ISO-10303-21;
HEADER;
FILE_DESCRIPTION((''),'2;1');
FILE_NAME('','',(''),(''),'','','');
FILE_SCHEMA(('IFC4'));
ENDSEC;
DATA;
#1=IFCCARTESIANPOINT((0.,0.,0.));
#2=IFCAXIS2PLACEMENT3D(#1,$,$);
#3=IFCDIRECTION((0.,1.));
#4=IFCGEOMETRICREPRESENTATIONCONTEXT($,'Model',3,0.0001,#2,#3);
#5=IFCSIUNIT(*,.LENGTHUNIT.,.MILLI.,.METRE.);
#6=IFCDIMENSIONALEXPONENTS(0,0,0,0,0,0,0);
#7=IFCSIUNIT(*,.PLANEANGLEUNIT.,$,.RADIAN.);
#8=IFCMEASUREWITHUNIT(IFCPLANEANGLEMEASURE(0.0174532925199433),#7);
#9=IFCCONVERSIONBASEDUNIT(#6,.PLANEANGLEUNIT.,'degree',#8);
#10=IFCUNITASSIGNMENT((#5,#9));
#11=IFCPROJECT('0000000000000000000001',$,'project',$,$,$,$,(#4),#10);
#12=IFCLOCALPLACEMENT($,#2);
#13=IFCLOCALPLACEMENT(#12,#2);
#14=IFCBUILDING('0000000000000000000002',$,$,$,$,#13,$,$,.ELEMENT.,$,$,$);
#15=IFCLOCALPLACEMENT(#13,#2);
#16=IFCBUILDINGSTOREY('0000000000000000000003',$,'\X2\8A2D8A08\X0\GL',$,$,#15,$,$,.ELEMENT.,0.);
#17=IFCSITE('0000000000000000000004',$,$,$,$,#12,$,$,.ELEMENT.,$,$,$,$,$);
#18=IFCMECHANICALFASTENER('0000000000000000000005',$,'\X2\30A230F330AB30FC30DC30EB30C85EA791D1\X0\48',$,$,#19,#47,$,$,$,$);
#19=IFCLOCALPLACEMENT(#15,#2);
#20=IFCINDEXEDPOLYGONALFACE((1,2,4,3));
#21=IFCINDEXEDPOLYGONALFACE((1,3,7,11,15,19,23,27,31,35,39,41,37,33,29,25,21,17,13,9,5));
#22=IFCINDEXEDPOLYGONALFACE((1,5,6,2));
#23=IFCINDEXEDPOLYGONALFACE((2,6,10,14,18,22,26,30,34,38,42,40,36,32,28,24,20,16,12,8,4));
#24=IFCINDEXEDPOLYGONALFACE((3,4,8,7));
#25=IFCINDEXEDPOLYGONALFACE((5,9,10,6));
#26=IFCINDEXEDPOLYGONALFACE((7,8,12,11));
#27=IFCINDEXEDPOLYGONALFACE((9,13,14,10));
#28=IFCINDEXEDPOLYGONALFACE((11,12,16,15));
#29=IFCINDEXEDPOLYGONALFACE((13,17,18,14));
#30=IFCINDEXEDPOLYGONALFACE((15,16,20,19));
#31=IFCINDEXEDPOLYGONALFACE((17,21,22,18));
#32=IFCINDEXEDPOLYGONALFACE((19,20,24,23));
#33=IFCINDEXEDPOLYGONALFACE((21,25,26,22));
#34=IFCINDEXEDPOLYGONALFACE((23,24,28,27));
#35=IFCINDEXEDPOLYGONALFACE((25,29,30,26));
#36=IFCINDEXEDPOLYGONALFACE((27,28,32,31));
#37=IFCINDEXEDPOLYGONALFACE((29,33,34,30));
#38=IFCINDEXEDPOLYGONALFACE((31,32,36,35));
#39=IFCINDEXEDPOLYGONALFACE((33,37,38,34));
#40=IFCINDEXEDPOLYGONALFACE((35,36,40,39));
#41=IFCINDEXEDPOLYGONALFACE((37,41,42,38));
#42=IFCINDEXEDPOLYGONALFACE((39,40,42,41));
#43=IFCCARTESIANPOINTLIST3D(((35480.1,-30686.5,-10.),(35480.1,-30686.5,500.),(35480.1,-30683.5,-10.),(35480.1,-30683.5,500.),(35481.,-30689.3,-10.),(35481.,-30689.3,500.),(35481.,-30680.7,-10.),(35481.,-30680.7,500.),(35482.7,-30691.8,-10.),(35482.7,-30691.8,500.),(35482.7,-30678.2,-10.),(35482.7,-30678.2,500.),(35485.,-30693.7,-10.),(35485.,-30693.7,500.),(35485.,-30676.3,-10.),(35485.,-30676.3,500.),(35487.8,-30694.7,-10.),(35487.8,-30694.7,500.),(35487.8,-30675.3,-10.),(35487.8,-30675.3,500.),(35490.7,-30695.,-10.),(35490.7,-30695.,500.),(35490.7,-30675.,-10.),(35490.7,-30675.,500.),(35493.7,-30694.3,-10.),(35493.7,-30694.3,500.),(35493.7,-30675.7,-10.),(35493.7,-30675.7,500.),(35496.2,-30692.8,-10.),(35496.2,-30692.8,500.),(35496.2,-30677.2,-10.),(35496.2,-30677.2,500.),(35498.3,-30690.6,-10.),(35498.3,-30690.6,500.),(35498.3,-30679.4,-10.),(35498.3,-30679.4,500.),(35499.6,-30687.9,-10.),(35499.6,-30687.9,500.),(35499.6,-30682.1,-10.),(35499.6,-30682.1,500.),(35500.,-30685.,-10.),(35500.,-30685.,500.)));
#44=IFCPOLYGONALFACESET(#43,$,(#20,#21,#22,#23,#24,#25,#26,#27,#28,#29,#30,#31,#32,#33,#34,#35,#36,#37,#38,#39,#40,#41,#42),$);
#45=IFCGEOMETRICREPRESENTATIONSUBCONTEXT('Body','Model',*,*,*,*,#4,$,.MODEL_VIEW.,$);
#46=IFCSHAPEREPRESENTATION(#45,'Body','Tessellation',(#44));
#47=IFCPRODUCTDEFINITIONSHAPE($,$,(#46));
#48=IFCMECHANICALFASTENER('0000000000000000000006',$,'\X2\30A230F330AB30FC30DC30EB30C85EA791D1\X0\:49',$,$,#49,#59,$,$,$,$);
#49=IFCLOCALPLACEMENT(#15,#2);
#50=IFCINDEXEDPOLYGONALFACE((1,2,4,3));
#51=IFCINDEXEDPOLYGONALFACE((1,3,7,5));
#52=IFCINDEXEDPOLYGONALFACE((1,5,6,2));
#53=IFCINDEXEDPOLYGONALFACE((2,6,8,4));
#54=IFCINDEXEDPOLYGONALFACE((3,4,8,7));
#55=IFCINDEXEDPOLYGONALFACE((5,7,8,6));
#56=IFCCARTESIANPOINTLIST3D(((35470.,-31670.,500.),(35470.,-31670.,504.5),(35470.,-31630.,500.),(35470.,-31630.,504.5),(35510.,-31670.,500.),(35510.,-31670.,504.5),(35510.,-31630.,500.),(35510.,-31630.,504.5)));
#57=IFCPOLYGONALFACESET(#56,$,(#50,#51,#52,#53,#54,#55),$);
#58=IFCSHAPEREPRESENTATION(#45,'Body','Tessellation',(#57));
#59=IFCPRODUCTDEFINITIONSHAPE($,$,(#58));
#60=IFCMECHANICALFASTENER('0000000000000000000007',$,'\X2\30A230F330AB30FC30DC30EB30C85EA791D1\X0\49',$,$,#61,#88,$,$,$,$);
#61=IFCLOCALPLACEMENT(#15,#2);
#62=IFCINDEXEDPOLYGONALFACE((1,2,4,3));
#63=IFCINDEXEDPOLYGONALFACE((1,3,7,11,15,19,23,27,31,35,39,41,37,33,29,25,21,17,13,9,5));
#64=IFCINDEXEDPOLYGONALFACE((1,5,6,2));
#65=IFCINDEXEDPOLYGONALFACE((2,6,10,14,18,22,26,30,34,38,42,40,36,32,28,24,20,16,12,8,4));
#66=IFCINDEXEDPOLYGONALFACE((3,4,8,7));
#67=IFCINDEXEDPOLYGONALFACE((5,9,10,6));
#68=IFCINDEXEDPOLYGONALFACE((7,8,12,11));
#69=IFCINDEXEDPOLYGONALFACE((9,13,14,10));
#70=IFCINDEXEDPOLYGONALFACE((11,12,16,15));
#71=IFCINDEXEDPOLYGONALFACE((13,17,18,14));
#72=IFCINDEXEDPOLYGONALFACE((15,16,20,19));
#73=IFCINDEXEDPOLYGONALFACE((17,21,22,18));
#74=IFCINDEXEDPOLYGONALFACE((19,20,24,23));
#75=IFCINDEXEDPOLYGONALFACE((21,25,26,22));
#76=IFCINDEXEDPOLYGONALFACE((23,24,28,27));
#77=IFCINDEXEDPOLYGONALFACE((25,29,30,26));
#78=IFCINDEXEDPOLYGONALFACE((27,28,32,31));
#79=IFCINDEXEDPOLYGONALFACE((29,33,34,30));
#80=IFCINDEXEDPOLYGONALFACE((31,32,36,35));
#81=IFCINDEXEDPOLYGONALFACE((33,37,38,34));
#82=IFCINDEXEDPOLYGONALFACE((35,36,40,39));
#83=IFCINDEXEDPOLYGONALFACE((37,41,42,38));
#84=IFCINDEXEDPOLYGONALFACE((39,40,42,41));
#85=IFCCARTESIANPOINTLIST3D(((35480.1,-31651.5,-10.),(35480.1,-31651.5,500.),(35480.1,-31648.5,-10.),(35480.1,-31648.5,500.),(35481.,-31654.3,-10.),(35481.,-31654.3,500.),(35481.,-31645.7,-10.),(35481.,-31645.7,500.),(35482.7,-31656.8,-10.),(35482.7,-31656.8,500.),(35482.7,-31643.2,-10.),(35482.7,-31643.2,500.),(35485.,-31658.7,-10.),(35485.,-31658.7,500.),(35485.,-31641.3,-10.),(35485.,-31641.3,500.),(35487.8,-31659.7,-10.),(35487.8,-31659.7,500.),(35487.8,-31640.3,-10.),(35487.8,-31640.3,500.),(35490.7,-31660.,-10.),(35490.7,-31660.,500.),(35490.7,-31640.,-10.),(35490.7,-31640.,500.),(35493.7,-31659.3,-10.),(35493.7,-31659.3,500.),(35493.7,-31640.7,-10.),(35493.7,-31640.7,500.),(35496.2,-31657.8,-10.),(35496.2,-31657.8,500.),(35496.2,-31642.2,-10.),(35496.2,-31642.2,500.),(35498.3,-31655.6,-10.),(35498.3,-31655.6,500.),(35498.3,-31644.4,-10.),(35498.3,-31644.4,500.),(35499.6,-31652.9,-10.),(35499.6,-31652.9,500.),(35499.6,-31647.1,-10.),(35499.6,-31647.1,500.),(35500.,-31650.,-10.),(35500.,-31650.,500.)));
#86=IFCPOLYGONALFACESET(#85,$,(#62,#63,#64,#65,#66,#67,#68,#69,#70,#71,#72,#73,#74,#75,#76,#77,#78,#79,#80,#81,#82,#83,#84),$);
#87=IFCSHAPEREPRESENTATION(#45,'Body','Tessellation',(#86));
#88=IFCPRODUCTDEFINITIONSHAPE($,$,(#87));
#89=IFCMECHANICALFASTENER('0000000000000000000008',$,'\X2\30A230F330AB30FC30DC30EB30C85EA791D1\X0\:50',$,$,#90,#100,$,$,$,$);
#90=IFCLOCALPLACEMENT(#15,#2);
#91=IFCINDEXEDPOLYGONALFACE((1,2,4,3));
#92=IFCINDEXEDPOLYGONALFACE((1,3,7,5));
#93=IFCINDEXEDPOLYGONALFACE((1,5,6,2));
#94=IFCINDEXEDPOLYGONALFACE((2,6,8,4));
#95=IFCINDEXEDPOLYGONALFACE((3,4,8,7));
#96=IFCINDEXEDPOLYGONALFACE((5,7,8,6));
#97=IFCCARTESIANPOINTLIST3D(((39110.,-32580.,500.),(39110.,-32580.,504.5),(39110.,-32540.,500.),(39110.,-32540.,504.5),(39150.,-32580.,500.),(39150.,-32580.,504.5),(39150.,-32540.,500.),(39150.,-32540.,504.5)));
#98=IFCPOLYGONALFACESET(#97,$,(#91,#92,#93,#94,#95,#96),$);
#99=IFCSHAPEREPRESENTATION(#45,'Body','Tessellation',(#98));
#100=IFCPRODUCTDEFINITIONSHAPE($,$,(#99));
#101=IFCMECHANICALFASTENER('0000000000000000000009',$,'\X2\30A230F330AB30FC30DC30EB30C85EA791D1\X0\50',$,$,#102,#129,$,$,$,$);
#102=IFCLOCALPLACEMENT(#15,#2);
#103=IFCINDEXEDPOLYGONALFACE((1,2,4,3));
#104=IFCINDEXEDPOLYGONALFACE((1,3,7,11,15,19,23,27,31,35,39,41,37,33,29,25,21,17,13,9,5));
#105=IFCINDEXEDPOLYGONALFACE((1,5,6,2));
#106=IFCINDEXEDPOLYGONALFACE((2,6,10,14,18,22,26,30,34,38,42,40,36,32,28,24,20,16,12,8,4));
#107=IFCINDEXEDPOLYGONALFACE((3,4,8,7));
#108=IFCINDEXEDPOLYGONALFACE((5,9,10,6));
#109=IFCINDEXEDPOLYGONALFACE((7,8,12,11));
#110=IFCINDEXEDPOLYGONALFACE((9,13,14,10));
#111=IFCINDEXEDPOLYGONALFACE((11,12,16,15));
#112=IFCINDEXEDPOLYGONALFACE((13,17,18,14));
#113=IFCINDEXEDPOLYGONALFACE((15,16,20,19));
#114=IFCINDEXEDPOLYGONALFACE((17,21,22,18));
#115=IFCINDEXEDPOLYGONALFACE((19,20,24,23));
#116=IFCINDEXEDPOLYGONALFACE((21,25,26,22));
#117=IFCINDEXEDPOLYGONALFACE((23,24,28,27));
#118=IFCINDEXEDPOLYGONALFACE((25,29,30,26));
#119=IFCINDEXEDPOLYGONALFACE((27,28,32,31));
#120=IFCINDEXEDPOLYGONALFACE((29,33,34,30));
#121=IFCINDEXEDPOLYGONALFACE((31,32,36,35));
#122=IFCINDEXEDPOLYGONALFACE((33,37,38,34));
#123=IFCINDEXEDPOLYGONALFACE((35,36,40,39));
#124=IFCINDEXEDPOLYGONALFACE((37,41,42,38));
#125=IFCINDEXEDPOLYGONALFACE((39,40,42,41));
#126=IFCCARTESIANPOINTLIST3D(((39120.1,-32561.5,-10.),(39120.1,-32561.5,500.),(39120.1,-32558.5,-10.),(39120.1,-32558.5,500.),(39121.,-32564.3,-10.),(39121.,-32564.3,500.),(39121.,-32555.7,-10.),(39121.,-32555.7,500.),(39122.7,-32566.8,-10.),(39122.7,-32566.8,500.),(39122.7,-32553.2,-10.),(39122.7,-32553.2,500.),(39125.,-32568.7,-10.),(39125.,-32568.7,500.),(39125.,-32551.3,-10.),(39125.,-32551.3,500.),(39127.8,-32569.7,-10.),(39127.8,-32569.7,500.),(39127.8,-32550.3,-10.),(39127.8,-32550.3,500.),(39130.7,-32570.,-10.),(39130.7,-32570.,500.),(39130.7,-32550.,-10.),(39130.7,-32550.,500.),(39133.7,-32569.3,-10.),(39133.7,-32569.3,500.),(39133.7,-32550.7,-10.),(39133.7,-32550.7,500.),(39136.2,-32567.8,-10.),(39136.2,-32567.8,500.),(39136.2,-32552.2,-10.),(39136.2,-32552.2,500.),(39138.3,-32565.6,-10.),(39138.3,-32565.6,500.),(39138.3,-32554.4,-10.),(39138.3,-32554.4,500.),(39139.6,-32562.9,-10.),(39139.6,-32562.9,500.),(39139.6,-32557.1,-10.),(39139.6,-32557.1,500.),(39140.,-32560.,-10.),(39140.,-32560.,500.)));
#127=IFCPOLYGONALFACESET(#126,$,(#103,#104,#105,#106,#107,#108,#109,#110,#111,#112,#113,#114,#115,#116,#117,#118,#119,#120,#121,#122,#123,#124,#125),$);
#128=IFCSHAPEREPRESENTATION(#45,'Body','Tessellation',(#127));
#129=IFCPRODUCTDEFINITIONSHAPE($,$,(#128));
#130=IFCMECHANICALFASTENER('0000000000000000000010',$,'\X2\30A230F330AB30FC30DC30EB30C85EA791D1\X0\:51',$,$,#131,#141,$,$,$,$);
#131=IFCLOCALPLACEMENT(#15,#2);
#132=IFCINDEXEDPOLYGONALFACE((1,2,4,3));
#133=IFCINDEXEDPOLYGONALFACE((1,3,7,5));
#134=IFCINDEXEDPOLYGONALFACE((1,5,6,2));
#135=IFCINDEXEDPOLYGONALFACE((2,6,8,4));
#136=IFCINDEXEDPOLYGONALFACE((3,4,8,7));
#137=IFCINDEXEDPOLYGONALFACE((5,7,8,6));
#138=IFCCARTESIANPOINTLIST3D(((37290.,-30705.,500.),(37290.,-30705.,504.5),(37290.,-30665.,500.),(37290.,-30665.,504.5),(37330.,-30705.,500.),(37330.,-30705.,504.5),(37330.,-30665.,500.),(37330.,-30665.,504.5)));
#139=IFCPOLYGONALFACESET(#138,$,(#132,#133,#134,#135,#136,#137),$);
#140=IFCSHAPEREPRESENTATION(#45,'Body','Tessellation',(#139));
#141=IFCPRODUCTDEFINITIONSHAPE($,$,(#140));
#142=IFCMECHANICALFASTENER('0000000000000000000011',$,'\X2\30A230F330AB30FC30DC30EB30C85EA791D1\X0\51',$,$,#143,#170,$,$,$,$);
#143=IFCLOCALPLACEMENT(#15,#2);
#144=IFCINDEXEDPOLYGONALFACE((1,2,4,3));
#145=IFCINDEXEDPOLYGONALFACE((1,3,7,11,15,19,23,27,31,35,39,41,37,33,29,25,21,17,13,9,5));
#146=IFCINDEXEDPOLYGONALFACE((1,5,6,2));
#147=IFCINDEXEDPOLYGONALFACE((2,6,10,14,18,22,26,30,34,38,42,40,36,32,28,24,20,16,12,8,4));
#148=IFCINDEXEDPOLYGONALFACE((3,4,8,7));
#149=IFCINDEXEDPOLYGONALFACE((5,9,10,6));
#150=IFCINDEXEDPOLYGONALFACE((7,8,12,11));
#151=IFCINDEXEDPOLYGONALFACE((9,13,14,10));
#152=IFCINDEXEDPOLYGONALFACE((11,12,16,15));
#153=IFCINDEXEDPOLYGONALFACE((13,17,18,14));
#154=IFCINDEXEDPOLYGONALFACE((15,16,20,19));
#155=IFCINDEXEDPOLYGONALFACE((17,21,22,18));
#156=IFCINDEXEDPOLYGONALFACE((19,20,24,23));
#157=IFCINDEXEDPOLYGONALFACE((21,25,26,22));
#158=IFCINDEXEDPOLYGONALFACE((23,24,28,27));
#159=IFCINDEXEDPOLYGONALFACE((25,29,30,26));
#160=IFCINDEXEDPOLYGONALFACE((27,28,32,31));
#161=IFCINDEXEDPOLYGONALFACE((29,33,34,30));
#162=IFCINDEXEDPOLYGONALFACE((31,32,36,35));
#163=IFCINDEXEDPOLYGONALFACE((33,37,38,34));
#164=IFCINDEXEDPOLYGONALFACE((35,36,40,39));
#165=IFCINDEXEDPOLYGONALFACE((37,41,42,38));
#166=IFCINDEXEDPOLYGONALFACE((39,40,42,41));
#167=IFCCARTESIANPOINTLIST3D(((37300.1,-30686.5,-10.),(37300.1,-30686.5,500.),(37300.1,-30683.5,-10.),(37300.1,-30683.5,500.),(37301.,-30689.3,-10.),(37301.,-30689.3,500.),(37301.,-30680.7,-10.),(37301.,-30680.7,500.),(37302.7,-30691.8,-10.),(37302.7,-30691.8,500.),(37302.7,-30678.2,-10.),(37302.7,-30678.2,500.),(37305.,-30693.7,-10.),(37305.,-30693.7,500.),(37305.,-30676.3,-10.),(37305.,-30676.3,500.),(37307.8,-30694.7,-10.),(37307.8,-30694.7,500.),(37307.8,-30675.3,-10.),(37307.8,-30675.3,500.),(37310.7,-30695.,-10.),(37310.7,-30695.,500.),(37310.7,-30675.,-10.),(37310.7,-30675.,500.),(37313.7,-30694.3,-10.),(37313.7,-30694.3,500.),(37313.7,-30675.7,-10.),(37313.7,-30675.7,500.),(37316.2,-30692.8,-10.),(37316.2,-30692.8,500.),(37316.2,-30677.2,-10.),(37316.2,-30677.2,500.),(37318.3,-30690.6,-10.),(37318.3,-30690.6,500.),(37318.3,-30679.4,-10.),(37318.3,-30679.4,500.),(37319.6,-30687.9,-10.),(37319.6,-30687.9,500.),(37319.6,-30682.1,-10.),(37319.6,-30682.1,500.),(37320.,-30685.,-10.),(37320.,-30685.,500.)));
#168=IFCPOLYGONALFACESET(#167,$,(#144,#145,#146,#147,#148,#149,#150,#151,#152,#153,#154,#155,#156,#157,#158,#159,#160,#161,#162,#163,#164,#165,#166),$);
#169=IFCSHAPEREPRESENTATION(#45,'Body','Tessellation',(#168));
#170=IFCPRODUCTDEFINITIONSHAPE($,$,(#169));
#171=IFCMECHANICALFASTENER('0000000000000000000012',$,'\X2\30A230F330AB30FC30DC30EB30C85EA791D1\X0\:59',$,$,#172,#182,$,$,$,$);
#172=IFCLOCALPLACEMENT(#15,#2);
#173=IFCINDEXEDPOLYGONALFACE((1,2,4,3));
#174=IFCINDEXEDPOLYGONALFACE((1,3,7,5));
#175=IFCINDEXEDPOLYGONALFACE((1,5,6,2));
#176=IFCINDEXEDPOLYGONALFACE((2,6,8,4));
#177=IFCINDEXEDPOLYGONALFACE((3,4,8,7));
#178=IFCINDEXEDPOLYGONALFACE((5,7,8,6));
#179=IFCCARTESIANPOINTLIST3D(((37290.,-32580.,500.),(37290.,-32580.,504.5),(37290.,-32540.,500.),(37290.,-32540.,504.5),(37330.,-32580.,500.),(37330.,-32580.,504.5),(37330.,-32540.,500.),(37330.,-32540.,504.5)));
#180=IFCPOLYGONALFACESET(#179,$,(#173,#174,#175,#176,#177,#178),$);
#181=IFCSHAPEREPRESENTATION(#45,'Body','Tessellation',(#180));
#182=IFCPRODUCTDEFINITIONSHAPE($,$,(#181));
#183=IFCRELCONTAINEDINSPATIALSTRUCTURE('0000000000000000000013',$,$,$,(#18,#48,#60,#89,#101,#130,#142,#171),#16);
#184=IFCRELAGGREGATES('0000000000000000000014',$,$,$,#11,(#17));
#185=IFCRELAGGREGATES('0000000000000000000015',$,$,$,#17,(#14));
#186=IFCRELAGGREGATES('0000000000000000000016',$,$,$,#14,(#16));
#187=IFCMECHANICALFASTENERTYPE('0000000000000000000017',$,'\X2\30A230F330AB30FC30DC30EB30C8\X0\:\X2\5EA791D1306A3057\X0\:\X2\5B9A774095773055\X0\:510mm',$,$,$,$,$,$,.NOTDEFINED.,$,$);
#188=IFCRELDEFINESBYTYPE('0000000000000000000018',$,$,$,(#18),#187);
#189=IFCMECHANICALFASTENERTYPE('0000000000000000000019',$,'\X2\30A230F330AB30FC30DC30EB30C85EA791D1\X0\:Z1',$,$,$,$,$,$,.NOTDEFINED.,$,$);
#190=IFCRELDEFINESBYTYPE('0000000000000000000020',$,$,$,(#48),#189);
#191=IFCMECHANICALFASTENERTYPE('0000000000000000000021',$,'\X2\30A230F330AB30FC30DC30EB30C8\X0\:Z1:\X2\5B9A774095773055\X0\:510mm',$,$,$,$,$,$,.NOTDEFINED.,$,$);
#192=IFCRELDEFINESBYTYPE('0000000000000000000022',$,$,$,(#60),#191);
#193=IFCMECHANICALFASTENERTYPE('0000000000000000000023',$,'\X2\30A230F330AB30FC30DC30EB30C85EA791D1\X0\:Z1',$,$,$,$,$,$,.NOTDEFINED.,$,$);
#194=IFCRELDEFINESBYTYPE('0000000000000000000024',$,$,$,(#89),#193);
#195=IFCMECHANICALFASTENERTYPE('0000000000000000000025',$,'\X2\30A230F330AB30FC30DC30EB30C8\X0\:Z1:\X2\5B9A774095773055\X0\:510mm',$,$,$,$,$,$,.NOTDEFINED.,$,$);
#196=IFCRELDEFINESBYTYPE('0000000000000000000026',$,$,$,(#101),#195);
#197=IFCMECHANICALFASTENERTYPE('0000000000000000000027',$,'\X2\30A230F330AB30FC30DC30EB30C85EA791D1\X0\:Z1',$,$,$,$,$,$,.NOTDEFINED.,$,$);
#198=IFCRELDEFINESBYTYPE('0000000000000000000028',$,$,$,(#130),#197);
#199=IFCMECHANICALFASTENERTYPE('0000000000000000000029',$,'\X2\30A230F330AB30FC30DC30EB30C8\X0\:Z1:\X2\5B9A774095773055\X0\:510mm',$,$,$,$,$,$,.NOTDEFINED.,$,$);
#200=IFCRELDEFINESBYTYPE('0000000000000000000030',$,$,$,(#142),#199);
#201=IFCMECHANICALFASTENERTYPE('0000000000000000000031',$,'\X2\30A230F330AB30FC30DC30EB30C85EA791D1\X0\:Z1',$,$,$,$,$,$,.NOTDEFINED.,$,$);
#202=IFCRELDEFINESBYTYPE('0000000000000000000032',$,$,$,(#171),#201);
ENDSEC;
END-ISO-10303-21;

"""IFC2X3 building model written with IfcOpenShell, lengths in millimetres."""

from ifc_helpers import new_model, entity, si_unit, converted_unit, direction, frame, origin, origin_with_axes, origin_2d, place, context, subcontext, project, spatial, rectangle, circle, extrude, type_object, element, save


model = new_model("IFC2X3")

# Units and contexts
model_context = context("Model", 3, precision=0.0001, world=origin(), true_north=direction((0.0, 1.0)))
body_context = subcontext(model_context, "Body", "Model", "MODEL_VIEW")
ifc_project = project(units=[si_unit("LENGTHUNIT", "METRE", prefix="MILLI"), converted_unit("PLANEANGLEUNIT", "degree", entity("IfcPlaneAngleMeasure", 0.0174532925199433), si_unit("PLANEANGLEUNIT", "RADIAN"), dimensions=[0, 0, 0, 0, 0, 0, 0])], contexts=[model_context])

# Site, building, storey
site_placement = place(None, origin())
site = spatial("IfcSite", under=ifc_project, at=site_placement, CompositionType="ELEMENT")
building_placement = place(site_placement, origin())
building = spatial("IfcBuilding", under=site, at=building_placement, CompositionType="ELEMENT")
storey_placement = place(building_placement, origin())
storey = spatial("IfcBuildingStorey", under=building, at=storey_placement, Name="設計GL", CompositionType="ELEMENT", Elevation=0.0)

# Mechanical fasteners
mechanical_fastener_type_1 = type_object("IfcMechanicalFastenerType", Name="アンカーボルト:座金なし:定着長さ:510mm")
mechanical_fastener_1_placement = place(storey_placement, frame((35490.0, -30685.0, -10.0)))
element("IfcMechanicalFastener", 1, at=mechanical_fastener_1_placement, inside=storey, type_object=mechanical_fastener_type_1, Name="アンカーボルト座金48", context=body_context, shape_type="SweptSolid", body=[
    extrude(circle(Radius=10.0, at=origin_2d()), origin_with_axes(), (0.0, 0.0, 1.0), 510.0),
])
mechanical_fastener_type_2 = type_object("IfcMechanicalFastenerType", Name="アンカーボルト座金:Z1")
mechanical_fastener_2_placement = place(storey_placement, frame((35490.0, -31650.0, 500.0)))
element("IfcMechanicalFastener", 2, at=mechanical_fastener_2_placement, inside=storey, type_object=mechanical_fastener_type_2, Name="アンカーボルト座金:49", context=body_context, shape_type="SweptSolid", body=[
    extrude(rectangle(XDim=40.0, YDim=40.0, at=origin_2d()), origin_with_axes(), (0.0, 0.0, 1.0), 4.5),
])
mechanical_fastener_type_3 = type_object("IfcMechanicalFastenerType", Name="アンカーボルト:Z1:定着長さ:510mm")
mechanical_fastener_3_placement = place(storey_placement, frame((35490.0, -31650.0, -10.0)))
element("IfcMechanicalFastener", 3, at=mechanical_fastener_3_placement, inside=storey, type_object=mechanical_fastener_type_3, Name="アンカーボルト座金49", context=body_context, shape_type="SweptSolid", body=[
    extrude(circle(Radius=10.0, at=origin_2d()), origin_with_axes(), (0.0, 0.0, 1.0), 510.0),
])
mechanical_fastener_type_4 = type_object("IfcMechanicalFastenerType", Name="アンカーボルト座金:Z1")
mechanical_fastener_4_placement = place(storey_placement, frame((39130.0, -32560.0, 500.0)))
element("IfcMechanicalFastener", 4, at=mechanical_fastener_4_placement, inside=storey, type_object=mechanical_fastener_type_4, Name="アンカーボルト座金:50", context=body_context, shape_type="SweptSolid", body=[
    extrude(rectangle(XDim=40.0, YDim=40.0, at=origin_2d()), origin_with_axes(), (0.0, 0.0, 1.0), 4.5),
])
mechanical_fastener_type_5 = type_object("IfcMechanicalFastenerType", Name="アンカーボルト:Z1:定着長さ:510mm")
mechanical_fastener_5_placement = place(storey_placement, frame((39130.0, -32560.0, -10.0)))
element("IfcMechanicalFastener", 5, at=mechanical_fastener_5_placement, inside=storey, type_object=mechanical_fastener_type_5, Name="アンカーボルト座金50", context=body_context, shape_type="SweptSolid", body=[
    extrude(circle(Radius=10.0, at=origin_2d()), origin_with_axes(), (0.0, 0.0, 1.0), 510.0),
])
mechanical_fastener_type_6 = type_object("IfcMechanicalFastenerType", Name="アンカーボルト座金:Z1")
mechanical_fastener_6_placement = place(storey_placement, frame((37310.0, -30685.0, 500.0)))
element("IfcMechanicalFastener", 6, at=mechanical_fastener_6_placement, inside=storey, type_object=mechanical_fastener_type_6, Name="アンカーボルト座金:51", context=body_context, shape_type="SweptSolid", body=[
    extrude(rectangle(XDim=40.0, YDim=40.0, at=origin_2d()), origin_with_axes(), (0.0, 0.0, 1.0), 4.5),
])
mechanical_fastener_type_7 = type_object("IfcMechanicalFastenerType", Name="アンカーボルト:Z1:定着長さ:510mm")
mechanical_fastener_7_placement = place(storey_placement, frame((37310.0, -30685.0, -10.0)))
element("IfcMechanicalFastener", 7, at=mechanical_fastener_7_placement, inside=storey, type_object=mechanical_fastener_type_7, Name="アンカーボルト座金51", context=body_context, shape_type="SweptSolid", body=[
    extrude(circle(Radius=10.0, at=origin_2d()), origin_with_axes(), (0.0, 0.0, 1.0), 510.0),
])
mechanical_fastener_type_8 = type_object("IfcMechanicalFastenerType", Name="アンカーボルト座金:Z1")
mechanical_fastener_8_placement = place(storey_placement, frame((37310.0, -32560.0, 500.0)))
element("IfcMechanicalFastener", 8, at=mechanical_fastener_8_placement, inside=storey, type_object=mechanical_fastener_type_8, Name="アンカーボルト座金:59", context=body_context, shape_type="SweptSolid", body=[
    extrude(rectangle(XDim=40.0, YDim=40.0, at=origin_2d()), origin_with_axes(), (0.0, 0.0, 1.0), 4.5),
])

save(model, "model.ifc")
